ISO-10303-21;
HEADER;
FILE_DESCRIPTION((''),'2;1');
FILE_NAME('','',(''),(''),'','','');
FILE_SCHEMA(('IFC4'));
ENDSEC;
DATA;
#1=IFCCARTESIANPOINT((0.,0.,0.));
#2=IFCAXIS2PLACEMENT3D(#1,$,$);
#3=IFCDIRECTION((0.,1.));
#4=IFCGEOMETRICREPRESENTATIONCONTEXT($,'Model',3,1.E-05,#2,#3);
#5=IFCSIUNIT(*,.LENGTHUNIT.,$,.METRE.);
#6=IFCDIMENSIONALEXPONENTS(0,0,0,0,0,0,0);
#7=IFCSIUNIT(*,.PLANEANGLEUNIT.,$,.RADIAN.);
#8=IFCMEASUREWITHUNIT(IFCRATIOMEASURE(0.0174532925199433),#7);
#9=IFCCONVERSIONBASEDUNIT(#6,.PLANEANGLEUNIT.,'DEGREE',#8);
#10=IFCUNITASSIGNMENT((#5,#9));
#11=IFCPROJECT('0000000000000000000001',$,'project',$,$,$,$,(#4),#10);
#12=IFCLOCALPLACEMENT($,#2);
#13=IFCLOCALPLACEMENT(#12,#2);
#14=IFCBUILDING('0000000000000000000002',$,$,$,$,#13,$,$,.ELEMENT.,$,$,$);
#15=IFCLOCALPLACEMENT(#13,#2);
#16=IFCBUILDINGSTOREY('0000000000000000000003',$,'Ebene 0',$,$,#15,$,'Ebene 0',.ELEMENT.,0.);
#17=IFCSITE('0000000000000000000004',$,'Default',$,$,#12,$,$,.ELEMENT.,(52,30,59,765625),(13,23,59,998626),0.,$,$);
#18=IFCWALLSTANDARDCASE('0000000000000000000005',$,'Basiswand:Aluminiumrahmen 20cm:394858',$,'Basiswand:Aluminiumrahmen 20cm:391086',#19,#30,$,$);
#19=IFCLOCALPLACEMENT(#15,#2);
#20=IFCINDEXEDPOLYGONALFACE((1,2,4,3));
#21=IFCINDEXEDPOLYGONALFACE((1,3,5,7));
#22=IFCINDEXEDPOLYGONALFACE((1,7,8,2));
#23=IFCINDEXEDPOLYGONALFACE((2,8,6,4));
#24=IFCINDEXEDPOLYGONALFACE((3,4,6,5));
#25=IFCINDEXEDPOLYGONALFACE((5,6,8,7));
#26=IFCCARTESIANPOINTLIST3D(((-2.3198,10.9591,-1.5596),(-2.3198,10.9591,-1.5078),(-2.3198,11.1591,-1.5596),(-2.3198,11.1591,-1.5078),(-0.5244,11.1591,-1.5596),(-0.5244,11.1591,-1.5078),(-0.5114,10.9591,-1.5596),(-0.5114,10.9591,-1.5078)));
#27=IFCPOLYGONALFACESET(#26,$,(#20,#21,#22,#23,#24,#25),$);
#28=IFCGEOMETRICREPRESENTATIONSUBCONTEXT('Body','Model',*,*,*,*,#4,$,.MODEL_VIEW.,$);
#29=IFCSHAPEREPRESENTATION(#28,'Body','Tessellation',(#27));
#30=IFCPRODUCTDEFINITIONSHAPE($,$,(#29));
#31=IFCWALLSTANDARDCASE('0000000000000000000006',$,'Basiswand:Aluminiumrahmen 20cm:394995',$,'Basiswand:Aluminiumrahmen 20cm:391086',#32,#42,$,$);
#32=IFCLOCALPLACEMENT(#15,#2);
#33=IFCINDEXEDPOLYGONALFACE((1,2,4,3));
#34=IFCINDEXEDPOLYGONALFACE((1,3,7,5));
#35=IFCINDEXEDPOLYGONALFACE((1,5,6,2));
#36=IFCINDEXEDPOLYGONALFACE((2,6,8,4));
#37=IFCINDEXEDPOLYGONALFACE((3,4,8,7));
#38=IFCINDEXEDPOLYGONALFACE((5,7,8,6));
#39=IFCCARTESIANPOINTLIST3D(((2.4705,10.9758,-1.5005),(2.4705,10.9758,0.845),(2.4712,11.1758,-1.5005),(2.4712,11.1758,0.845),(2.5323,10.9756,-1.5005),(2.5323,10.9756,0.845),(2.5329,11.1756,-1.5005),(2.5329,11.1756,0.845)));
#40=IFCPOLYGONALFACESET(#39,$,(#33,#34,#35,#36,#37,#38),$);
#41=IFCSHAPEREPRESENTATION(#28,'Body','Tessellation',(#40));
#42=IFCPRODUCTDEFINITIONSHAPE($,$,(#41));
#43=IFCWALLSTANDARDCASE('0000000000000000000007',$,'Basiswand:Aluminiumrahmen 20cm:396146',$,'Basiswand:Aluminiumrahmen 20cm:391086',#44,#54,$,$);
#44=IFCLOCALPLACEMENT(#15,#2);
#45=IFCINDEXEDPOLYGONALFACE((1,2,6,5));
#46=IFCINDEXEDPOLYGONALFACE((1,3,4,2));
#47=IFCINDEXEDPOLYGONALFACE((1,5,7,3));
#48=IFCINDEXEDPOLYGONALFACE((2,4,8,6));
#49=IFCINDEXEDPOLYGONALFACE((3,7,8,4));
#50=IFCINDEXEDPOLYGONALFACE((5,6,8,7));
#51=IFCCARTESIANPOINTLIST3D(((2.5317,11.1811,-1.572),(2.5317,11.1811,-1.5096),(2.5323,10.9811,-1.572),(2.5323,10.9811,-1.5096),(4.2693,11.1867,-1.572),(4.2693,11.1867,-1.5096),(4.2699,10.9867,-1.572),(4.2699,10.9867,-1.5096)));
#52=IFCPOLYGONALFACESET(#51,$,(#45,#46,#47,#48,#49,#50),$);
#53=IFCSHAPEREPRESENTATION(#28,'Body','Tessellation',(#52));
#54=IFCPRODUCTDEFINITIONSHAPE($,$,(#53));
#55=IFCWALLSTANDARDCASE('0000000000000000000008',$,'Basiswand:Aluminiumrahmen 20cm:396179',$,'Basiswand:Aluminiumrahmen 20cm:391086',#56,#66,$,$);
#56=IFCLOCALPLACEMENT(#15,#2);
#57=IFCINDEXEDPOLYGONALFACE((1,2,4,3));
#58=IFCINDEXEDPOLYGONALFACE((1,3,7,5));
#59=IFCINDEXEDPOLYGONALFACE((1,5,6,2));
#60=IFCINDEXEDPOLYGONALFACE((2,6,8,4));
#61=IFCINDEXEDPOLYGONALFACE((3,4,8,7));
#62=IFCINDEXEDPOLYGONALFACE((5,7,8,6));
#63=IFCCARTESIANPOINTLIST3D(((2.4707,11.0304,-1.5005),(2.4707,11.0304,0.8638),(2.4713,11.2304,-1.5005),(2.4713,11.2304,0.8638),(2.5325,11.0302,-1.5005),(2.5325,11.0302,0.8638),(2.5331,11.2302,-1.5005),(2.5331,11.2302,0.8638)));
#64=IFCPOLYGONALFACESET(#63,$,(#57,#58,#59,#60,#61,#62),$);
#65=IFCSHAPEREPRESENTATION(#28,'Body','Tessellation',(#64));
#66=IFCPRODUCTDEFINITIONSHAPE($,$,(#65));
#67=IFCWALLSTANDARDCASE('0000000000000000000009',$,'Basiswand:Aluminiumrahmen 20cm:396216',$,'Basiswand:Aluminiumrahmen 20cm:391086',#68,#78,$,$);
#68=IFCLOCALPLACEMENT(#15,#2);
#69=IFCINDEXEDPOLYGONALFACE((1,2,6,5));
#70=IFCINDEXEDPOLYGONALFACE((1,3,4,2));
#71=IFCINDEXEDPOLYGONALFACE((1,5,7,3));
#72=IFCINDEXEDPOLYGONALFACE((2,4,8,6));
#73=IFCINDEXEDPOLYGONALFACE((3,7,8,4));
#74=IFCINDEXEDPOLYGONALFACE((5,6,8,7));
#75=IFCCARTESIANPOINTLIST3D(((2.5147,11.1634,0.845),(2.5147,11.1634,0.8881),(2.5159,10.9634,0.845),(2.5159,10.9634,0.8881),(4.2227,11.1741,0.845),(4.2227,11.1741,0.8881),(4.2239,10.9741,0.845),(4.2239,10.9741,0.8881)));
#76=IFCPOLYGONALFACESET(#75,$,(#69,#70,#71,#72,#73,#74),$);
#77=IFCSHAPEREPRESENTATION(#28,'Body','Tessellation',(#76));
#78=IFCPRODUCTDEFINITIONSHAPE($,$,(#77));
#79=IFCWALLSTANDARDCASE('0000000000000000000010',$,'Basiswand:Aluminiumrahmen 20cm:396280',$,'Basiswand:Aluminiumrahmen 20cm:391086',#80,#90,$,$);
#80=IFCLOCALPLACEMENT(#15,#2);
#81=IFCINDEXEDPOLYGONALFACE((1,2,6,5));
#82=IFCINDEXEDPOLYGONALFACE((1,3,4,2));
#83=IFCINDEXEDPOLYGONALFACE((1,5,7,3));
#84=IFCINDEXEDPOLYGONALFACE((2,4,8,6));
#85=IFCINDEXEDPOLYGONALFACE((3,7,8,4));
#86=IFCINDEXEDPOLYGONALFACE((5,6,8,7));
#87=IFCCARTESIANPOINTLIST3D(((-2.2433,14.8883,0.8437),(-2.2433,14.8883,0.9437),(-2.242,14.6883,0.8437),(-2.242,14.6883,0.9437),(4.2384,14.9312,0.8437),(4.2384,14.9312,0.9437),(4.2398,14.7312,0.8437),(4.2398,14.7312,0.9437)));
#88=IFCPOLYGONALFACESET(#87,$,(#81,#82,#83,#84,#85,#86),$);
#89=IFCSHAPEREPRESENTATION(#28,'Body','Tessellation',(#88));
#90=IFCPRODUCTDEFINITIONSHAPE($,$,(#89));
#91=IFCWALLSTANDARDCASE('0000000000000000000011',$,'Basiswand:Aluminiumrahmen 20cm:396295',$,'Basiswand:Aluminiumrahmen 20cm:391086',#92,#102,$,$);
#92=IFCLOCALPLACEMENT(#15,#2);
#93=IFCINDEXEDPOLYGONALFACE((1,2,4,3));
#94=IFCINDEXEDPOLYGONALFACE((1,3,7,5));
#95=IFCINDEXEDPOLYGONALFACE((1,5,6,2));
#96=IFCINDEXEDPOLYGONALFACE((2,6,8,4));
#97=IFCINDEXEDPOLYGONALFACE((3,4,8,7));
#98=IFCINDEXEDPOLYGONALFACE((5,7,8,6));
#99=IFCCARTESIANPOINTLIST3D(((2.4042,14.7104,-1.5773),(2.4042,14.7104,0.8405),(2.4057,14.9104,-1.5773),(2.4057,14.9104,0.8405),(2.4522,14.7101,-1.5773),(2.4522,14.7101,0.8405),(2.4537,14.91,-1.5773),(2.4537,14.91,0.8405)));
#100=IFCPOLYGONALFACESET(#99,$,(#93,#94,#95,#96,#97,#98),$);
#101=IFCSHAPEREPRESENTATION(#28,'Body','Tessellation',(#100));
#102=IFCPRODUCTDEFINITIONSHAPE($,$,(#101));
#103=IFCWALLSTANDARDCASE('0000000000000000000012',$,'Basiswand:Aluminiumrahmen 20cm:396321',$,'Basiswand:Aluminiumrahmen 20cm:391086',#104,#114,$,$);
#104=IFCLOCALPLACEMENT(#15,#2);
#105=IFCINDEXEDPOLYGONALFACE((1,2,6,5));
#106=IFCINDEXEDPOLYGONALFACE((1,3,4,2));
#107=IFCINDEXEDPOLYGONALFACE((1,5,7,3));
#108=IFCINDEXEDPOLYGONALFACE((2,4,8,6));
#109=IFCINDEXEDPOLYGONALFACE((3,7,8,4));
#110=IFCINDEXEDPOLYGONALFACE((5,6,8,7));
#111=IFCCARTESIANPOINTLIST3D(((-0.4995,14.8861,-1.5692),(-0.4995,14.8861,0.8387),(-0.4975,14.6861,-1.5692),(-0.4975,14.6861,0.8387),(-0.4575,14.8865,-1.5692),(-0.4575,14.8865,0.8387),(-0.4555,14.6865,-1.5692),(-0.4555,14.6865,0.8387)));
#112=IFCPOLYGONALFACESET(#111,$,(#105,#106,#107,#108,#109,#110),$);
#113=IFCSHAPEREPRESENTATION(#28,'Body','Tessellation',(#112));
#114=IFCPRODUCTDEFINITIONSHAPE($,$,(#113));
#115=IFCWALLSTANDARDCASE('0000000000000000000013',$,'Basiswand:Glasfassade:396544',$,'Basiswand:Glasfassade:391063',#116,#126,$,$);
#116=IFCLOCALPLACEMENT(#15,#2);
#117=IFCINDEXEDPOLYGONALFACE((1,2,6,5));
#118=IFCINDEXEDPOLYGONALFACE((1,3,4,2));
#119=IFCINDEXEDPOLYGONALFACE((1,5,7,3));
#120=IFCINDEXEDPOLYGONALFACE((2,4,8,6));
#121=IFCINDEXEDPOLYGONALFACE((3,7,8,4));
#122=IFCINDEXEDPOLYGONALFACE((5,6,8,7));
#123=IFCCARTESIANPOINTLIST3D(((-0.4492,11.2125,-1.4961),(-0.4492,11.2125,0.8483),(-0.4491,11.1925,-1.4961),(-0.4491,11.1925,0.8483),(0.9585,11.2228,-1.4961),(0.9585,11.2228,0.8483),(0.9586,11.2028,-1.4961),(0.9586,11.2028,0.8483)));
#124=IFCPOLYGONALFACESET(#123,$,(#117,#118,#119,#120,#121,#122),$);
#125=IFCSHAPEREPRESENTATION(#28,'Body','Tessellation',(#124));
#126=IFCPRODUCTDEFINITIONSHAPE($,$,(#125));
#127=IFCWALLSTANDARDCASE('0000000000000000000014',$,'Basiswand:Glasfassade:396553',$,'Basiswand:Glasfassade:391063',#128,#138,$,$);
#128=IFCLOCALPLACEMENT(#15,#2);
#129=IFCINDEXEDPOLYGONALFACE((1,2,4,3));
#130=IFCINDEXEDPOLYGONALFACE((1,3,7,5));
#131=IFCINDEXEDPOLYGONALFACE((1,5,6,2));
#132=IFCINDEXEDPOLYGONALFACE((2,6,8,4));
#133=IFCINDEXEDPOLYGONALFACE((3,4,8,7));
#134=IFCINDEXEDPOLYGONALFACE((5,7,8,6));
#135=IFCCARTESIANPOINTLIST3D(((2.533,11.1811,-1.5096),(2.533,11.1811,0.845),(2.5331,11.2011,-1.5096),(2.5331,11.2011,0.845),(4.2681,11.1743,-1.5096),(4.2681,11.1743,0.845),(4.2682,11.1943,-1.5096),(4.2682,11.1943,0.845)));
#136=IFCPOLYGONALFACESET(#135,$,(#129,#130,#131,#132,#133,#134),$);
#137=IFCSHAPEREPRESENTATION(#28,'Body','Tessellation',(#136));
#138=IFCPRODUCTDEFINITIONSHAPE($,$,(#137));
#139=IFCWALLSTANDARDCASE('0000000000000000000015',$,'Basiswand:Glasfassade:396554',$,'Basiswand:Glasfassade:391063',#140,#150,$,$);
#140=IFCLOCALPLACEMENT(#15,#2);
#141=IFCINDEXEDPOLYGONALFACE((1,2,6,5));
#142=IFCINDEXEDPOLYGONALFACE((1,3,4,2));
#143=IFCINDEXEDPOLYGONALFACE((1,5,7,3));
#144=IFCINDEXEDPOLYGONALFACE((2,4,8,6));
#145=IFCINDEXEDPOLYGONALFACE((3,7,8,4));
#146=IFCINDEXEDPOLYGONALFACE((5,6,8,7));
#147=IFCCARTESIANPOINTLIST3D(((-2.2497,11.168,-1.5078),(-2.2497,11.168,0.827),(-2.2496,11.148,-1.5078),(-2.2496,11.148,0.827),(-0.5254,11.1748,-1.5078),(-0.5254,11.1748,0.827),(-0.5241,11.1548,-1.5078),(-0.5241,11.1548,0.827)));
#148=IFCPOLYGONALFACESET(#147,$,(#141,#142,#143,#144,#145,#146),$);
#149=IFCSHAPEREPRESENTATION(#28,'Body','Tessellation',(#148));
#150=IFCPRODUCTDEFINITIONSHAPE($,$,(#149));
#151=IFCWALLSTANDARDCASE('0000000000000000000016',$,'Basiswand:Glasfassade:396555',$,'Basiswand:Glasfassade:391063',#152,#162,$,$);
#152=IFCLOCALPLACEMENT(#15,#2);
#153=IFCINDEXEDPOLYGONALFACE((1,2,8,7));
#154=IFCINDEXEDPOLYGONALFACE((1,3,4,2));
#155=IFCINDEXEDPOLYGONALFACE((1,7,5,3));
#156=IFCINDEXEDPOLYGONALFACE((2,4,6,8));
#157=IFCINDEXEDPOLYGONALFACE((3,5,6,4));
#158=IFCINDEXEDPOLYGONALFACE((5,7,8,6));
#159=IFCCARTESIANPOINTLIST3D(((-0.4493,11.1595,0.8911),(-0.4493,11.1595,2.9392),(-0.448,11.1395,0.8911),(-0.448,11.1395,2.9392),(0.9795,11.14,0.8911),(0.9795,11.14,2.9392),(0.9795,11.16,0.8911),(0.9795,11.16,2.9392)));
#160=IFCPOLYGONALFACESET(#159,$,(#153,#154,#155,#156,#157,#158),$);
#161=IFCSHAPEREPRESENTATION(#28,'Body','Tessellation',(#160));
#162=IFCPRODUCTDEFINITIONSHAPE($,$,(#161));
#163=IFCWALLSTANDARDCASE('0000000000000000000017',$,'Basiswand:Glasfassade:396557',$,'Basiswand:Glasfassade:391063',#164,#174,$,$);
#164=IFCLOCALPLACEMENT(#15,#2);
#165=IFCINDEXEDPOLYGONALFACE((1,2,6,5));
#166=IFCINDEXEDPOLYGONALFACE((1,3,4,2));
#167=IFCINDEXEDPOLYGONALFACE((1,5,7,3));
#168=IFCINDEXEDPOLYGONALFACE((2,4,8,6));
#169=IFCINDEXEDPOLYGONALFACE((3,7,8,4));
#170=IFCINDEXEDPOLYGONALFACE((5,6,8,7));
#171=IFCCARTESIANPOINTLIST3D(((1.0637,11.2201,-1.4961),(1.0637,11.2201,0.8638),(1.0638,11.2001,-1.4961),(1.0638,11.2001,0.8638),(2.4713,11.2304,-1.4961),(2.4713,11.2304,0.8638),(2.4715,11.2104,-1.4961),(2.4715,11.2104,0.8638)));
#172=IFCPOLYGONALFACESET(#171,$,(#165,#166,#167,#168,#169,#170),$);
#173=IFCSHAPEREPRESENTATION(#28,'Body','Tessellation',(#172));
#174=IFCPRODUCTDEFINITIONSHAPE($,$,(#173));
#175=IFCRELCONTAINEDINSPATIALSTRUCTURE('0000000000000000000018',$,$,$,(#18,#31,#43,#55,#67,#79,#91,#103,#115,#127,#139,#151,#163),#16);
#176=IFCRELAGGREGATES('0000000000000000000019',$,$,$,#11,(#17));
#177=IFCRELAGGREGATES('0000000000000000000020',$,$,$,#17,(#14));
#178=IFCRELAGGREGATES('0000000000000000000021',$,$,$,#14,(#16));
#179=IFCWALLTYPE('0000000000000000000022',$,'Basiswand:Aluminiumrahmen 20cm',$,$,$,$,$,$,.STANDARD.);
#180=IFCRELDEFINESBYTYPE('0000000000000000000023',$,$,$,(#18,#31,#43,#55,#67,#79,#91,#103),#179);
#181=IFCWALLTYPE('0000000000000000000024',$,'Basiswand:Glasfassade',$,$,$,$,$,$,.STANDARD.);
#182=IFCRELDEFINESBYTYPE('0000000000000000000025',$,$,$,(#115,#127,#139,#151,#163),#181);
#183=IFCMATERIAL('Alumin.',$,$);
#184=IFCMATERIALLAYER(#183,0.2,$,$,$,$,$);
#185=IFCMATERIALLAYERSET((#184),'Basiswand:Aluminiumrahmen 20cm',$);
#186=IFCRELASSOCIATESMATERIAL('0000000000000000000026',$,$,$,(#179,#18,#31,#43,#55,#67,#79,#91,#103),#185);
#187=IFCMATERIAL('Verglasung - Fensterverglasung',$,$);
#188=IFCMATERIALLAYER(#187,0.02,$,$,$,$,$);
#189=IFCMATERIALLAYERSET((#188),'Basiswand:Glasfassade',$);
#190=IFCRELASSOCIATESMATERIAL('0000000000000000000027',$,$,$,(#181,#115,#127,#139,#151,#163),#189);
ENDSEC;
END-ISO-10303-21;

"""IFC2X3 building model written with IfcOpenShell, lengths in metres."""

from ifc_helpers import new_model, entity, si_unit, converted_unit, direction, frame, frame_2d, origin, place, context, subcontext, project, spatial, polyline, rectangle, outline, extrude, material, layer, layer_set, layer_usage, type_object, element, save


model = new_model("IFC2X3")

# Units and contexts
model_context = context("Model", 3, precision=1e-05, world=origin(), true_north=direction((0.0, 1.0)))
body_context = subcontext(model_context, "Body", "Model", "MODEL_VIEW")
ifc_project = project(units=[si_unit("LENGTHUNIT", "METRE"), converted_unit("PLANEANGLEUNIT", "DEGREE", entity("IfcRatioMeasure", 0.0174532925199433), si_unit("PLANEANGLEUNIT", "RADIAN"), dimensions=[0, 0, 0, 0, 0, 0, 0])], contexts=[model_context])

# Site, building, storey
site_placement = place(None, origin())
site = spatial("IfcSite", under=ifc_project, at=site_placement, Name="Default", CompositionType="ELEMENT", RefLatitude=(52, 30, 59, 765625), RefLongitude=(13, 23, 59, 998626), RefElevation=0.0)
building_placement = place(site_placement, origin())
building = spatial("IfcBuilding", under=site, at=building_placement, CompositionType="ELEMENT")
storey_placement = place(building_placement, origin())
storey = spatial("IfcBuildingStorey", under=building, at=storey_placement, Name="Ebene 0", LongName="Ebene 0", CompositionType="ELEMENT", Elevation=0.0)

# Walls
ifc_material_1 = material(Name="Alumin.")
ifc_layer_1 = layer(ifc_material_1, 0.2)
ifc_layer_set_1 = layer_set([ifc_layer_1], Name="Basiswand:Aluminiumrahmen 20cm")
wall_type_1 = type_object("IfcWallType", Name="Basiswand:Aluminiumrahmen 20cm", PredefinedType="STANDARD", material=ifc_layer_set_1)
ifc_layer_usage_1 = layer_usage(ifc_layer_set_1, "AXIS2", "POSITIVE", -0.1)
wall_1_placement = place(storey_placement, frame((-2.3198, 11.0591, -1.5596)))
element("IfcWallStandardCase", 1, at=wall_1_placement, inside=storey, type_object=wall_type_1, material=ifc_layer_usage_1, Name="Basiswand:Aluminiumrahmen 20cm:394858", ObjectType="Basiswand:Aluminiumrahmen 20cm:391086", context=body_context, shape_type="SweptSolid", body=[
    extrude(outline(polyline([(1.8084, -0.1), (1.7954, 0.1), (0.0, 0.1), (0.0, -0.1), (1.8084, -0.1)])), origin(), (0.0, 0.0, 1.0), 0.0517),
])
ifc_layer_usage_2 = layer_usage(ifc_layer_set_1, "AXIS2", "POSITIVE", -0.1)
wall_2_placement = place(storey_placement, frame((2.4709, 11.0758, -1.5005), z_axis=(0.0, 0.0, 1.0), x_axis=(0.999995, -0.003158, 0.0)))
element("IfcWallStandardCase", 2, at=wall_2_placement, inside=storey, type_object=wall_type_1, material=ifc_layer_usage_2, Name="Basiswand:Aluminiumrahmen 20cm:394995", ObjectType="Basiswand:Aluminiumrahmen 20cm:391086", context=body_context, shape_type="SweptSolid", body=[
    extrude(rectangle(XDim=0.0617, YDim=0.2, at=frame_2d((0.0309, 0.0), x_axis=(-1.0, 0.0))), origin(), (0.0, 0.0, 1.0), 2.3455),
])
ifc_layer_usage_3 = layer_usage(ifc_layer_set_1, "AXIS2", "POSITIVE", -0.1)
wall_3_placement = place(storey_placement, frame((2.532, 11.0811, -1.572), z_axis=(0.0, 0.0, 1.0), x_axis=(0.999995, 0.003224, 0.0)))
element("IfcWallStandardCase", 3, at=wall_3_placement, inside=storey, type_object=wall_type_1, material=ifc_layer_usage_3, Name="Basiswand:Aluminiumrahmen 20cm:396146", ObjectType="Basiswand:Aluminiumrahmen 20cm:391086", context=body_context, shape_type="SweptSolid", body=[
    extrude(rectangle(XDim=1.7376, YDim=0.2, at=frame_2d((0.8688, 0.0), x_axis=(-1.0, 0.0))), origin(), (0.0, 0.0, 1.0), 0.0624),
])
ifc_layer_usage_4 = layer_usage(ifc_layer_set_1, "AXIS2", "POSITIVE", -0.1)
wall_4_placement = place(storey_placement, frame((2.5328, 11.1302, -1.5005), z_axis=(0.0, 0.0, 1.0), x_axis=(-0.999995, 0.003158, 0.0)))
element("IfcWallStandardCase", 4, at=wall_4_placement, inside=storey, type_object=wall_type_1, material=ifc_layer_usage_4, Name="Basiswand:Aluminiumrahmen 20cm:396179", ObjectType="Basiswand:Aluminiumrahmen 20cm:391086", context=body_context, shape_type="SweptSolid", body=[
    extrude(rectangle(XDim=0.0618, YDim=0.2, at=frame_2d((0.0309, 0.0), x_axis=(-1.0, 0.0))), origin(), (0.0, 0.0, 1.0), 2.3643),
])
ifc_layer_usage_5 = layer_usage(ifc_layer_set_1, "AXIS2", "POSITIVE", -0.1)
wall_5_placement = place(storey_placement, frame((2.5153, 11.0634, 0.845), z_axis=(0.0, 0.0, 1.0), x_axis=(0.999981, 0.006237, 0.0)))
element("IfcWallStandardCase", 5, at=wall_5_placement, inside=storey, type_object=wall_type_1, material=ifc_layer_usage_5, Name="Basiswand:Aluminiumrahmen 20cm:396216", ObjectType="Basiswand:Aluminiumrahmen 20cm:391086", context=body_context, shape_type="SweptSolid", body=[
    extrude(rectangle(XDim=1.708, YDim=0.2, at=frame_2d((0.854, 0.0), x_axis=(-1.0, 0.0))), origin(), (0.0, 0.0, 1.0), 0.0431),
])
ifc_layer_usage_6 = layer_usage(ifc_layer_set_1, "AXIS2", "POSITIVE", -0.1)
wall_6_placement = place(storey_placement, frame((4.2391, 14.8312, 0.8437), z_axis=(0.0, 0.0, 1.0), x_axis=(-0.999978, -0.006605, 0.0)))
element("IfcWallStandardCase", 6, at=wall_6_placement, inside=storey, type_object=wall_type_1, material=ifc_layer_usage_6, Name="Basiswand:Aluminiumrahmen 20cm:396280", ObjectType="Basiswand:Aluminiumrahmen 20cm:391086", context=body_context, shape_type="SweptSolid", body=[
    extrude(rectangle(XDim=6.4819, YDim=0.2, at=frame_2d((3.2409, 0.0), x_axis=(-1.0, 0.0))), origin(), (0.0, 0.0, 1.0), 0.1),
])
ifc_layer_usage_7 = layer_usage(ifc_layer_set_1, "AXIS2", "POSITIVE", -0.1)
wall_7_placement = place(storey_placement, frame((2.453, 14.8101, -1.5773), z_axis=(0.0, 0.0, 1.0), x_axis=(-0.999971, 0.007644, 0.0)))
element("IfcWallStandardCase", 7, at=wall_7_placement, inside=storey, type_object=wall_type_1, material=ifc_layer_usage_7, Name="Basiswand:Aluminiumrahmen 20cm:396295", ObjectType="Basiswand:Aluminiumrahmen 20cm:391086", context=body_context, shape_type="SweptSolid", body=[
    extrude(rectangle(XDim=0.048, YDim=0.2, at=frame_2d((0.024, 0.0), x_axis=(-1.0, 0.0))), origin(), (0.0, 0.0, 1.0), 2.4179),
])
ifc_layer_usage_8 = layer_usage(ifc_layer_set_1, "AXIS2", "POSITIVE", -0.1)
wall_8_placement = place(storey_placement, frame((-0.4565, 14.7865, -1.5692), z_axis=(0.0, 0.0, 1.0), x_axis=(-0.999953, -0.009708, 0.0)))
element("IfcWallStandardCase", 8, at=wall_8_placement, inside=storey, type_object=wall_type_1, material=ifc_layer_usage_8, Name="Basiswand:Aluminiumrahmen 20cm:396321", ObjectType="Basiswand:Aluminiumrahmen 20cm:391086", context=body_context, shape_type="SweptSolid", body=[
    extrude(rectangle(XDim=0.042, YDim=0.2, at=frame_2d((0.021, 0.0), x_axis=(-1.0, 0.0))), origin(), (0.0, 0.0, 1.0), 2.4079),
])
ifc_material_2 = material(Name="Verglasung - Fensterverglasung")
ifc_layer_2 = layer(ifc_material_2, 0.02)
ifc_layer_set_2 = layer_set([ifc_layer_2], Name="Basiswand:Glasfassade")
ifc_layer_usage_9 = layer_usage(ifc_layer_set_2, "AXIS2", "POSITIVE", -0.01)
wall_type_2 = type_object("IfcWallType", Name="Basiswand:Glasfassade", PredefinedType="STANDARD", material=ifc_layer_set_2)
wall_9_placement = place(storey_placement, frame((0.9586, 11.2128, -1.4961), z_axis=(0.0, 0.0, 1.0), x_axis=(-0.999973, -0.007321, 0.0)))
element("IfcWallStandardCase", 9, at=wall_9_placement, inside=storey, type_object=wall_type_2, material=ifc_layer_usage_9, Name="Basiswand:Glasfassade:396544", ObjectType="Basiswand:Glasfassade:391063", context=body_context, shape_type="SweptSolid", body=[
    extrude(rectangle(XDim=1.4078, YDim=0.02, at=frame_2d((0.7039, 0.0), x_axis=(-1.0, 0.0))), origin(), (0.0, 0.0, 1.0), 2.3443),
])
ifc_layer_usage_10 = layer_usage(ifc_layer_set_2, "AXIS2", "POSITIVE", -0.01)
wall_10_placement = place(storey_placement, frame((2.533, 11.1911, -1.5096), z_axis=(0.0, 0.0, 1.0), x_axis=(0.999992, -0.003897, 0.0)))
element("IfcWallStandardCase", 10, at=wall_10_placement, inside=storey, type_object=wall_type_2, material=ifc_layer_usage_10, Name="Basiswand:Glasfassade:396553", ObjectType="Basiswand:Glasfassade:391063", context=body_context, shape_type="SweptSolid", body=[
    extrude(rectangle(XDim=1.7352, YDim=0.02, at=frame_2d((0.8676, 0.0), x_axis=(-1.0, 0.0))), origin(), (0.0, 0.0, 1.0), 2.3547),
])
ifc_layer_usage_11 = layer_usage(ifc_layer_set_2, "AXIS2", "POSITIVE", -0.01)
wall_11_placement = place(storey_placement, frame((-2.2496, 11.158, -1.5078), z_axis=(0.0, 0.0, 1.0), x_axis=(0.999992, 0.003985, 0.0)))
element("IfcWallStandardCase", 11, at=wall_11_placement, inside=storey, type_object=wall_type_2, material=ifc_layer_usage_11, Name="Basiswand:Glasfassade:396554", ObjectType="Basiswand:Glasfassade:391063", context=body_context, shape_type="SweptSolid", body=[
    extrude(outline(polyline([(1.7255, -0.01), (1.7243, 0.01), (0.0, 0.01), (0.0, -0.01), (1.7255, -0.01)])), origin(), (0.0, 0.0, 1.0), 2.3349),
])
ifc_layer_usage_12 = layer_usage(ifc_layer_set_2, "AXIS2", "POSITIVE", -0.01)
wall_12_placement = place(storey_placement, frame((0.9795, 11.15, 0.8911), z_axis=(0.0, 0.0, 1.0), x_axis=(-1.0, -0.00038, 0.0)))
element("IfcWallStandardCase", 12, at=wall_12_placement, inside=storey, type_object=wall_type_2, material=ifc_layer_usage_12, Name="Basiswand:Glasfassade:396555", ObjectType="Basiswand:Glasfassade:391063", context=body_context, shape_type="SweptSolid", body=[
    extrude(outline(polyline([(1.4288, -0.01), (1.4275, 0.01), (0.0, 0.01), (0.0, -0.01), (1.4288, -0.01)])), origin(), (0.0, 0.0, 1.0), 2.0481),
])
ifc_layer_usage_13 = layer_usage(ifc_layer_set_2, "AXIS2", "POSITIVE", -0.01)
wall_13_placement = place(storey_placement, frame((2.4714, 11.2204, -1.4961), z_axis=(0.0, 0.0, 1.0), x_axis=(-0.999973, -0.007321, 0.0)))
element("IfcWallStandardCase", 13, at=wall_13_placement, inside=storey, type_object=wall_type_2, material=ifc_layer_usage_13, Name="Basiswand:Glasfassade:396557", ObjectType="Basiswand:Glasfassade:391063", context=body_context, shape_type="SweptSolid", body=[
    extrude(rectangle(XDim=1.4077, YDim=0.02, at=frame_2d((0.7038, 0.0), x_axis=(-1.0, 0.0))), origin(), (0.0, 0.0, 1.0), 2.3598),
])

save(model, "model.ifc")
